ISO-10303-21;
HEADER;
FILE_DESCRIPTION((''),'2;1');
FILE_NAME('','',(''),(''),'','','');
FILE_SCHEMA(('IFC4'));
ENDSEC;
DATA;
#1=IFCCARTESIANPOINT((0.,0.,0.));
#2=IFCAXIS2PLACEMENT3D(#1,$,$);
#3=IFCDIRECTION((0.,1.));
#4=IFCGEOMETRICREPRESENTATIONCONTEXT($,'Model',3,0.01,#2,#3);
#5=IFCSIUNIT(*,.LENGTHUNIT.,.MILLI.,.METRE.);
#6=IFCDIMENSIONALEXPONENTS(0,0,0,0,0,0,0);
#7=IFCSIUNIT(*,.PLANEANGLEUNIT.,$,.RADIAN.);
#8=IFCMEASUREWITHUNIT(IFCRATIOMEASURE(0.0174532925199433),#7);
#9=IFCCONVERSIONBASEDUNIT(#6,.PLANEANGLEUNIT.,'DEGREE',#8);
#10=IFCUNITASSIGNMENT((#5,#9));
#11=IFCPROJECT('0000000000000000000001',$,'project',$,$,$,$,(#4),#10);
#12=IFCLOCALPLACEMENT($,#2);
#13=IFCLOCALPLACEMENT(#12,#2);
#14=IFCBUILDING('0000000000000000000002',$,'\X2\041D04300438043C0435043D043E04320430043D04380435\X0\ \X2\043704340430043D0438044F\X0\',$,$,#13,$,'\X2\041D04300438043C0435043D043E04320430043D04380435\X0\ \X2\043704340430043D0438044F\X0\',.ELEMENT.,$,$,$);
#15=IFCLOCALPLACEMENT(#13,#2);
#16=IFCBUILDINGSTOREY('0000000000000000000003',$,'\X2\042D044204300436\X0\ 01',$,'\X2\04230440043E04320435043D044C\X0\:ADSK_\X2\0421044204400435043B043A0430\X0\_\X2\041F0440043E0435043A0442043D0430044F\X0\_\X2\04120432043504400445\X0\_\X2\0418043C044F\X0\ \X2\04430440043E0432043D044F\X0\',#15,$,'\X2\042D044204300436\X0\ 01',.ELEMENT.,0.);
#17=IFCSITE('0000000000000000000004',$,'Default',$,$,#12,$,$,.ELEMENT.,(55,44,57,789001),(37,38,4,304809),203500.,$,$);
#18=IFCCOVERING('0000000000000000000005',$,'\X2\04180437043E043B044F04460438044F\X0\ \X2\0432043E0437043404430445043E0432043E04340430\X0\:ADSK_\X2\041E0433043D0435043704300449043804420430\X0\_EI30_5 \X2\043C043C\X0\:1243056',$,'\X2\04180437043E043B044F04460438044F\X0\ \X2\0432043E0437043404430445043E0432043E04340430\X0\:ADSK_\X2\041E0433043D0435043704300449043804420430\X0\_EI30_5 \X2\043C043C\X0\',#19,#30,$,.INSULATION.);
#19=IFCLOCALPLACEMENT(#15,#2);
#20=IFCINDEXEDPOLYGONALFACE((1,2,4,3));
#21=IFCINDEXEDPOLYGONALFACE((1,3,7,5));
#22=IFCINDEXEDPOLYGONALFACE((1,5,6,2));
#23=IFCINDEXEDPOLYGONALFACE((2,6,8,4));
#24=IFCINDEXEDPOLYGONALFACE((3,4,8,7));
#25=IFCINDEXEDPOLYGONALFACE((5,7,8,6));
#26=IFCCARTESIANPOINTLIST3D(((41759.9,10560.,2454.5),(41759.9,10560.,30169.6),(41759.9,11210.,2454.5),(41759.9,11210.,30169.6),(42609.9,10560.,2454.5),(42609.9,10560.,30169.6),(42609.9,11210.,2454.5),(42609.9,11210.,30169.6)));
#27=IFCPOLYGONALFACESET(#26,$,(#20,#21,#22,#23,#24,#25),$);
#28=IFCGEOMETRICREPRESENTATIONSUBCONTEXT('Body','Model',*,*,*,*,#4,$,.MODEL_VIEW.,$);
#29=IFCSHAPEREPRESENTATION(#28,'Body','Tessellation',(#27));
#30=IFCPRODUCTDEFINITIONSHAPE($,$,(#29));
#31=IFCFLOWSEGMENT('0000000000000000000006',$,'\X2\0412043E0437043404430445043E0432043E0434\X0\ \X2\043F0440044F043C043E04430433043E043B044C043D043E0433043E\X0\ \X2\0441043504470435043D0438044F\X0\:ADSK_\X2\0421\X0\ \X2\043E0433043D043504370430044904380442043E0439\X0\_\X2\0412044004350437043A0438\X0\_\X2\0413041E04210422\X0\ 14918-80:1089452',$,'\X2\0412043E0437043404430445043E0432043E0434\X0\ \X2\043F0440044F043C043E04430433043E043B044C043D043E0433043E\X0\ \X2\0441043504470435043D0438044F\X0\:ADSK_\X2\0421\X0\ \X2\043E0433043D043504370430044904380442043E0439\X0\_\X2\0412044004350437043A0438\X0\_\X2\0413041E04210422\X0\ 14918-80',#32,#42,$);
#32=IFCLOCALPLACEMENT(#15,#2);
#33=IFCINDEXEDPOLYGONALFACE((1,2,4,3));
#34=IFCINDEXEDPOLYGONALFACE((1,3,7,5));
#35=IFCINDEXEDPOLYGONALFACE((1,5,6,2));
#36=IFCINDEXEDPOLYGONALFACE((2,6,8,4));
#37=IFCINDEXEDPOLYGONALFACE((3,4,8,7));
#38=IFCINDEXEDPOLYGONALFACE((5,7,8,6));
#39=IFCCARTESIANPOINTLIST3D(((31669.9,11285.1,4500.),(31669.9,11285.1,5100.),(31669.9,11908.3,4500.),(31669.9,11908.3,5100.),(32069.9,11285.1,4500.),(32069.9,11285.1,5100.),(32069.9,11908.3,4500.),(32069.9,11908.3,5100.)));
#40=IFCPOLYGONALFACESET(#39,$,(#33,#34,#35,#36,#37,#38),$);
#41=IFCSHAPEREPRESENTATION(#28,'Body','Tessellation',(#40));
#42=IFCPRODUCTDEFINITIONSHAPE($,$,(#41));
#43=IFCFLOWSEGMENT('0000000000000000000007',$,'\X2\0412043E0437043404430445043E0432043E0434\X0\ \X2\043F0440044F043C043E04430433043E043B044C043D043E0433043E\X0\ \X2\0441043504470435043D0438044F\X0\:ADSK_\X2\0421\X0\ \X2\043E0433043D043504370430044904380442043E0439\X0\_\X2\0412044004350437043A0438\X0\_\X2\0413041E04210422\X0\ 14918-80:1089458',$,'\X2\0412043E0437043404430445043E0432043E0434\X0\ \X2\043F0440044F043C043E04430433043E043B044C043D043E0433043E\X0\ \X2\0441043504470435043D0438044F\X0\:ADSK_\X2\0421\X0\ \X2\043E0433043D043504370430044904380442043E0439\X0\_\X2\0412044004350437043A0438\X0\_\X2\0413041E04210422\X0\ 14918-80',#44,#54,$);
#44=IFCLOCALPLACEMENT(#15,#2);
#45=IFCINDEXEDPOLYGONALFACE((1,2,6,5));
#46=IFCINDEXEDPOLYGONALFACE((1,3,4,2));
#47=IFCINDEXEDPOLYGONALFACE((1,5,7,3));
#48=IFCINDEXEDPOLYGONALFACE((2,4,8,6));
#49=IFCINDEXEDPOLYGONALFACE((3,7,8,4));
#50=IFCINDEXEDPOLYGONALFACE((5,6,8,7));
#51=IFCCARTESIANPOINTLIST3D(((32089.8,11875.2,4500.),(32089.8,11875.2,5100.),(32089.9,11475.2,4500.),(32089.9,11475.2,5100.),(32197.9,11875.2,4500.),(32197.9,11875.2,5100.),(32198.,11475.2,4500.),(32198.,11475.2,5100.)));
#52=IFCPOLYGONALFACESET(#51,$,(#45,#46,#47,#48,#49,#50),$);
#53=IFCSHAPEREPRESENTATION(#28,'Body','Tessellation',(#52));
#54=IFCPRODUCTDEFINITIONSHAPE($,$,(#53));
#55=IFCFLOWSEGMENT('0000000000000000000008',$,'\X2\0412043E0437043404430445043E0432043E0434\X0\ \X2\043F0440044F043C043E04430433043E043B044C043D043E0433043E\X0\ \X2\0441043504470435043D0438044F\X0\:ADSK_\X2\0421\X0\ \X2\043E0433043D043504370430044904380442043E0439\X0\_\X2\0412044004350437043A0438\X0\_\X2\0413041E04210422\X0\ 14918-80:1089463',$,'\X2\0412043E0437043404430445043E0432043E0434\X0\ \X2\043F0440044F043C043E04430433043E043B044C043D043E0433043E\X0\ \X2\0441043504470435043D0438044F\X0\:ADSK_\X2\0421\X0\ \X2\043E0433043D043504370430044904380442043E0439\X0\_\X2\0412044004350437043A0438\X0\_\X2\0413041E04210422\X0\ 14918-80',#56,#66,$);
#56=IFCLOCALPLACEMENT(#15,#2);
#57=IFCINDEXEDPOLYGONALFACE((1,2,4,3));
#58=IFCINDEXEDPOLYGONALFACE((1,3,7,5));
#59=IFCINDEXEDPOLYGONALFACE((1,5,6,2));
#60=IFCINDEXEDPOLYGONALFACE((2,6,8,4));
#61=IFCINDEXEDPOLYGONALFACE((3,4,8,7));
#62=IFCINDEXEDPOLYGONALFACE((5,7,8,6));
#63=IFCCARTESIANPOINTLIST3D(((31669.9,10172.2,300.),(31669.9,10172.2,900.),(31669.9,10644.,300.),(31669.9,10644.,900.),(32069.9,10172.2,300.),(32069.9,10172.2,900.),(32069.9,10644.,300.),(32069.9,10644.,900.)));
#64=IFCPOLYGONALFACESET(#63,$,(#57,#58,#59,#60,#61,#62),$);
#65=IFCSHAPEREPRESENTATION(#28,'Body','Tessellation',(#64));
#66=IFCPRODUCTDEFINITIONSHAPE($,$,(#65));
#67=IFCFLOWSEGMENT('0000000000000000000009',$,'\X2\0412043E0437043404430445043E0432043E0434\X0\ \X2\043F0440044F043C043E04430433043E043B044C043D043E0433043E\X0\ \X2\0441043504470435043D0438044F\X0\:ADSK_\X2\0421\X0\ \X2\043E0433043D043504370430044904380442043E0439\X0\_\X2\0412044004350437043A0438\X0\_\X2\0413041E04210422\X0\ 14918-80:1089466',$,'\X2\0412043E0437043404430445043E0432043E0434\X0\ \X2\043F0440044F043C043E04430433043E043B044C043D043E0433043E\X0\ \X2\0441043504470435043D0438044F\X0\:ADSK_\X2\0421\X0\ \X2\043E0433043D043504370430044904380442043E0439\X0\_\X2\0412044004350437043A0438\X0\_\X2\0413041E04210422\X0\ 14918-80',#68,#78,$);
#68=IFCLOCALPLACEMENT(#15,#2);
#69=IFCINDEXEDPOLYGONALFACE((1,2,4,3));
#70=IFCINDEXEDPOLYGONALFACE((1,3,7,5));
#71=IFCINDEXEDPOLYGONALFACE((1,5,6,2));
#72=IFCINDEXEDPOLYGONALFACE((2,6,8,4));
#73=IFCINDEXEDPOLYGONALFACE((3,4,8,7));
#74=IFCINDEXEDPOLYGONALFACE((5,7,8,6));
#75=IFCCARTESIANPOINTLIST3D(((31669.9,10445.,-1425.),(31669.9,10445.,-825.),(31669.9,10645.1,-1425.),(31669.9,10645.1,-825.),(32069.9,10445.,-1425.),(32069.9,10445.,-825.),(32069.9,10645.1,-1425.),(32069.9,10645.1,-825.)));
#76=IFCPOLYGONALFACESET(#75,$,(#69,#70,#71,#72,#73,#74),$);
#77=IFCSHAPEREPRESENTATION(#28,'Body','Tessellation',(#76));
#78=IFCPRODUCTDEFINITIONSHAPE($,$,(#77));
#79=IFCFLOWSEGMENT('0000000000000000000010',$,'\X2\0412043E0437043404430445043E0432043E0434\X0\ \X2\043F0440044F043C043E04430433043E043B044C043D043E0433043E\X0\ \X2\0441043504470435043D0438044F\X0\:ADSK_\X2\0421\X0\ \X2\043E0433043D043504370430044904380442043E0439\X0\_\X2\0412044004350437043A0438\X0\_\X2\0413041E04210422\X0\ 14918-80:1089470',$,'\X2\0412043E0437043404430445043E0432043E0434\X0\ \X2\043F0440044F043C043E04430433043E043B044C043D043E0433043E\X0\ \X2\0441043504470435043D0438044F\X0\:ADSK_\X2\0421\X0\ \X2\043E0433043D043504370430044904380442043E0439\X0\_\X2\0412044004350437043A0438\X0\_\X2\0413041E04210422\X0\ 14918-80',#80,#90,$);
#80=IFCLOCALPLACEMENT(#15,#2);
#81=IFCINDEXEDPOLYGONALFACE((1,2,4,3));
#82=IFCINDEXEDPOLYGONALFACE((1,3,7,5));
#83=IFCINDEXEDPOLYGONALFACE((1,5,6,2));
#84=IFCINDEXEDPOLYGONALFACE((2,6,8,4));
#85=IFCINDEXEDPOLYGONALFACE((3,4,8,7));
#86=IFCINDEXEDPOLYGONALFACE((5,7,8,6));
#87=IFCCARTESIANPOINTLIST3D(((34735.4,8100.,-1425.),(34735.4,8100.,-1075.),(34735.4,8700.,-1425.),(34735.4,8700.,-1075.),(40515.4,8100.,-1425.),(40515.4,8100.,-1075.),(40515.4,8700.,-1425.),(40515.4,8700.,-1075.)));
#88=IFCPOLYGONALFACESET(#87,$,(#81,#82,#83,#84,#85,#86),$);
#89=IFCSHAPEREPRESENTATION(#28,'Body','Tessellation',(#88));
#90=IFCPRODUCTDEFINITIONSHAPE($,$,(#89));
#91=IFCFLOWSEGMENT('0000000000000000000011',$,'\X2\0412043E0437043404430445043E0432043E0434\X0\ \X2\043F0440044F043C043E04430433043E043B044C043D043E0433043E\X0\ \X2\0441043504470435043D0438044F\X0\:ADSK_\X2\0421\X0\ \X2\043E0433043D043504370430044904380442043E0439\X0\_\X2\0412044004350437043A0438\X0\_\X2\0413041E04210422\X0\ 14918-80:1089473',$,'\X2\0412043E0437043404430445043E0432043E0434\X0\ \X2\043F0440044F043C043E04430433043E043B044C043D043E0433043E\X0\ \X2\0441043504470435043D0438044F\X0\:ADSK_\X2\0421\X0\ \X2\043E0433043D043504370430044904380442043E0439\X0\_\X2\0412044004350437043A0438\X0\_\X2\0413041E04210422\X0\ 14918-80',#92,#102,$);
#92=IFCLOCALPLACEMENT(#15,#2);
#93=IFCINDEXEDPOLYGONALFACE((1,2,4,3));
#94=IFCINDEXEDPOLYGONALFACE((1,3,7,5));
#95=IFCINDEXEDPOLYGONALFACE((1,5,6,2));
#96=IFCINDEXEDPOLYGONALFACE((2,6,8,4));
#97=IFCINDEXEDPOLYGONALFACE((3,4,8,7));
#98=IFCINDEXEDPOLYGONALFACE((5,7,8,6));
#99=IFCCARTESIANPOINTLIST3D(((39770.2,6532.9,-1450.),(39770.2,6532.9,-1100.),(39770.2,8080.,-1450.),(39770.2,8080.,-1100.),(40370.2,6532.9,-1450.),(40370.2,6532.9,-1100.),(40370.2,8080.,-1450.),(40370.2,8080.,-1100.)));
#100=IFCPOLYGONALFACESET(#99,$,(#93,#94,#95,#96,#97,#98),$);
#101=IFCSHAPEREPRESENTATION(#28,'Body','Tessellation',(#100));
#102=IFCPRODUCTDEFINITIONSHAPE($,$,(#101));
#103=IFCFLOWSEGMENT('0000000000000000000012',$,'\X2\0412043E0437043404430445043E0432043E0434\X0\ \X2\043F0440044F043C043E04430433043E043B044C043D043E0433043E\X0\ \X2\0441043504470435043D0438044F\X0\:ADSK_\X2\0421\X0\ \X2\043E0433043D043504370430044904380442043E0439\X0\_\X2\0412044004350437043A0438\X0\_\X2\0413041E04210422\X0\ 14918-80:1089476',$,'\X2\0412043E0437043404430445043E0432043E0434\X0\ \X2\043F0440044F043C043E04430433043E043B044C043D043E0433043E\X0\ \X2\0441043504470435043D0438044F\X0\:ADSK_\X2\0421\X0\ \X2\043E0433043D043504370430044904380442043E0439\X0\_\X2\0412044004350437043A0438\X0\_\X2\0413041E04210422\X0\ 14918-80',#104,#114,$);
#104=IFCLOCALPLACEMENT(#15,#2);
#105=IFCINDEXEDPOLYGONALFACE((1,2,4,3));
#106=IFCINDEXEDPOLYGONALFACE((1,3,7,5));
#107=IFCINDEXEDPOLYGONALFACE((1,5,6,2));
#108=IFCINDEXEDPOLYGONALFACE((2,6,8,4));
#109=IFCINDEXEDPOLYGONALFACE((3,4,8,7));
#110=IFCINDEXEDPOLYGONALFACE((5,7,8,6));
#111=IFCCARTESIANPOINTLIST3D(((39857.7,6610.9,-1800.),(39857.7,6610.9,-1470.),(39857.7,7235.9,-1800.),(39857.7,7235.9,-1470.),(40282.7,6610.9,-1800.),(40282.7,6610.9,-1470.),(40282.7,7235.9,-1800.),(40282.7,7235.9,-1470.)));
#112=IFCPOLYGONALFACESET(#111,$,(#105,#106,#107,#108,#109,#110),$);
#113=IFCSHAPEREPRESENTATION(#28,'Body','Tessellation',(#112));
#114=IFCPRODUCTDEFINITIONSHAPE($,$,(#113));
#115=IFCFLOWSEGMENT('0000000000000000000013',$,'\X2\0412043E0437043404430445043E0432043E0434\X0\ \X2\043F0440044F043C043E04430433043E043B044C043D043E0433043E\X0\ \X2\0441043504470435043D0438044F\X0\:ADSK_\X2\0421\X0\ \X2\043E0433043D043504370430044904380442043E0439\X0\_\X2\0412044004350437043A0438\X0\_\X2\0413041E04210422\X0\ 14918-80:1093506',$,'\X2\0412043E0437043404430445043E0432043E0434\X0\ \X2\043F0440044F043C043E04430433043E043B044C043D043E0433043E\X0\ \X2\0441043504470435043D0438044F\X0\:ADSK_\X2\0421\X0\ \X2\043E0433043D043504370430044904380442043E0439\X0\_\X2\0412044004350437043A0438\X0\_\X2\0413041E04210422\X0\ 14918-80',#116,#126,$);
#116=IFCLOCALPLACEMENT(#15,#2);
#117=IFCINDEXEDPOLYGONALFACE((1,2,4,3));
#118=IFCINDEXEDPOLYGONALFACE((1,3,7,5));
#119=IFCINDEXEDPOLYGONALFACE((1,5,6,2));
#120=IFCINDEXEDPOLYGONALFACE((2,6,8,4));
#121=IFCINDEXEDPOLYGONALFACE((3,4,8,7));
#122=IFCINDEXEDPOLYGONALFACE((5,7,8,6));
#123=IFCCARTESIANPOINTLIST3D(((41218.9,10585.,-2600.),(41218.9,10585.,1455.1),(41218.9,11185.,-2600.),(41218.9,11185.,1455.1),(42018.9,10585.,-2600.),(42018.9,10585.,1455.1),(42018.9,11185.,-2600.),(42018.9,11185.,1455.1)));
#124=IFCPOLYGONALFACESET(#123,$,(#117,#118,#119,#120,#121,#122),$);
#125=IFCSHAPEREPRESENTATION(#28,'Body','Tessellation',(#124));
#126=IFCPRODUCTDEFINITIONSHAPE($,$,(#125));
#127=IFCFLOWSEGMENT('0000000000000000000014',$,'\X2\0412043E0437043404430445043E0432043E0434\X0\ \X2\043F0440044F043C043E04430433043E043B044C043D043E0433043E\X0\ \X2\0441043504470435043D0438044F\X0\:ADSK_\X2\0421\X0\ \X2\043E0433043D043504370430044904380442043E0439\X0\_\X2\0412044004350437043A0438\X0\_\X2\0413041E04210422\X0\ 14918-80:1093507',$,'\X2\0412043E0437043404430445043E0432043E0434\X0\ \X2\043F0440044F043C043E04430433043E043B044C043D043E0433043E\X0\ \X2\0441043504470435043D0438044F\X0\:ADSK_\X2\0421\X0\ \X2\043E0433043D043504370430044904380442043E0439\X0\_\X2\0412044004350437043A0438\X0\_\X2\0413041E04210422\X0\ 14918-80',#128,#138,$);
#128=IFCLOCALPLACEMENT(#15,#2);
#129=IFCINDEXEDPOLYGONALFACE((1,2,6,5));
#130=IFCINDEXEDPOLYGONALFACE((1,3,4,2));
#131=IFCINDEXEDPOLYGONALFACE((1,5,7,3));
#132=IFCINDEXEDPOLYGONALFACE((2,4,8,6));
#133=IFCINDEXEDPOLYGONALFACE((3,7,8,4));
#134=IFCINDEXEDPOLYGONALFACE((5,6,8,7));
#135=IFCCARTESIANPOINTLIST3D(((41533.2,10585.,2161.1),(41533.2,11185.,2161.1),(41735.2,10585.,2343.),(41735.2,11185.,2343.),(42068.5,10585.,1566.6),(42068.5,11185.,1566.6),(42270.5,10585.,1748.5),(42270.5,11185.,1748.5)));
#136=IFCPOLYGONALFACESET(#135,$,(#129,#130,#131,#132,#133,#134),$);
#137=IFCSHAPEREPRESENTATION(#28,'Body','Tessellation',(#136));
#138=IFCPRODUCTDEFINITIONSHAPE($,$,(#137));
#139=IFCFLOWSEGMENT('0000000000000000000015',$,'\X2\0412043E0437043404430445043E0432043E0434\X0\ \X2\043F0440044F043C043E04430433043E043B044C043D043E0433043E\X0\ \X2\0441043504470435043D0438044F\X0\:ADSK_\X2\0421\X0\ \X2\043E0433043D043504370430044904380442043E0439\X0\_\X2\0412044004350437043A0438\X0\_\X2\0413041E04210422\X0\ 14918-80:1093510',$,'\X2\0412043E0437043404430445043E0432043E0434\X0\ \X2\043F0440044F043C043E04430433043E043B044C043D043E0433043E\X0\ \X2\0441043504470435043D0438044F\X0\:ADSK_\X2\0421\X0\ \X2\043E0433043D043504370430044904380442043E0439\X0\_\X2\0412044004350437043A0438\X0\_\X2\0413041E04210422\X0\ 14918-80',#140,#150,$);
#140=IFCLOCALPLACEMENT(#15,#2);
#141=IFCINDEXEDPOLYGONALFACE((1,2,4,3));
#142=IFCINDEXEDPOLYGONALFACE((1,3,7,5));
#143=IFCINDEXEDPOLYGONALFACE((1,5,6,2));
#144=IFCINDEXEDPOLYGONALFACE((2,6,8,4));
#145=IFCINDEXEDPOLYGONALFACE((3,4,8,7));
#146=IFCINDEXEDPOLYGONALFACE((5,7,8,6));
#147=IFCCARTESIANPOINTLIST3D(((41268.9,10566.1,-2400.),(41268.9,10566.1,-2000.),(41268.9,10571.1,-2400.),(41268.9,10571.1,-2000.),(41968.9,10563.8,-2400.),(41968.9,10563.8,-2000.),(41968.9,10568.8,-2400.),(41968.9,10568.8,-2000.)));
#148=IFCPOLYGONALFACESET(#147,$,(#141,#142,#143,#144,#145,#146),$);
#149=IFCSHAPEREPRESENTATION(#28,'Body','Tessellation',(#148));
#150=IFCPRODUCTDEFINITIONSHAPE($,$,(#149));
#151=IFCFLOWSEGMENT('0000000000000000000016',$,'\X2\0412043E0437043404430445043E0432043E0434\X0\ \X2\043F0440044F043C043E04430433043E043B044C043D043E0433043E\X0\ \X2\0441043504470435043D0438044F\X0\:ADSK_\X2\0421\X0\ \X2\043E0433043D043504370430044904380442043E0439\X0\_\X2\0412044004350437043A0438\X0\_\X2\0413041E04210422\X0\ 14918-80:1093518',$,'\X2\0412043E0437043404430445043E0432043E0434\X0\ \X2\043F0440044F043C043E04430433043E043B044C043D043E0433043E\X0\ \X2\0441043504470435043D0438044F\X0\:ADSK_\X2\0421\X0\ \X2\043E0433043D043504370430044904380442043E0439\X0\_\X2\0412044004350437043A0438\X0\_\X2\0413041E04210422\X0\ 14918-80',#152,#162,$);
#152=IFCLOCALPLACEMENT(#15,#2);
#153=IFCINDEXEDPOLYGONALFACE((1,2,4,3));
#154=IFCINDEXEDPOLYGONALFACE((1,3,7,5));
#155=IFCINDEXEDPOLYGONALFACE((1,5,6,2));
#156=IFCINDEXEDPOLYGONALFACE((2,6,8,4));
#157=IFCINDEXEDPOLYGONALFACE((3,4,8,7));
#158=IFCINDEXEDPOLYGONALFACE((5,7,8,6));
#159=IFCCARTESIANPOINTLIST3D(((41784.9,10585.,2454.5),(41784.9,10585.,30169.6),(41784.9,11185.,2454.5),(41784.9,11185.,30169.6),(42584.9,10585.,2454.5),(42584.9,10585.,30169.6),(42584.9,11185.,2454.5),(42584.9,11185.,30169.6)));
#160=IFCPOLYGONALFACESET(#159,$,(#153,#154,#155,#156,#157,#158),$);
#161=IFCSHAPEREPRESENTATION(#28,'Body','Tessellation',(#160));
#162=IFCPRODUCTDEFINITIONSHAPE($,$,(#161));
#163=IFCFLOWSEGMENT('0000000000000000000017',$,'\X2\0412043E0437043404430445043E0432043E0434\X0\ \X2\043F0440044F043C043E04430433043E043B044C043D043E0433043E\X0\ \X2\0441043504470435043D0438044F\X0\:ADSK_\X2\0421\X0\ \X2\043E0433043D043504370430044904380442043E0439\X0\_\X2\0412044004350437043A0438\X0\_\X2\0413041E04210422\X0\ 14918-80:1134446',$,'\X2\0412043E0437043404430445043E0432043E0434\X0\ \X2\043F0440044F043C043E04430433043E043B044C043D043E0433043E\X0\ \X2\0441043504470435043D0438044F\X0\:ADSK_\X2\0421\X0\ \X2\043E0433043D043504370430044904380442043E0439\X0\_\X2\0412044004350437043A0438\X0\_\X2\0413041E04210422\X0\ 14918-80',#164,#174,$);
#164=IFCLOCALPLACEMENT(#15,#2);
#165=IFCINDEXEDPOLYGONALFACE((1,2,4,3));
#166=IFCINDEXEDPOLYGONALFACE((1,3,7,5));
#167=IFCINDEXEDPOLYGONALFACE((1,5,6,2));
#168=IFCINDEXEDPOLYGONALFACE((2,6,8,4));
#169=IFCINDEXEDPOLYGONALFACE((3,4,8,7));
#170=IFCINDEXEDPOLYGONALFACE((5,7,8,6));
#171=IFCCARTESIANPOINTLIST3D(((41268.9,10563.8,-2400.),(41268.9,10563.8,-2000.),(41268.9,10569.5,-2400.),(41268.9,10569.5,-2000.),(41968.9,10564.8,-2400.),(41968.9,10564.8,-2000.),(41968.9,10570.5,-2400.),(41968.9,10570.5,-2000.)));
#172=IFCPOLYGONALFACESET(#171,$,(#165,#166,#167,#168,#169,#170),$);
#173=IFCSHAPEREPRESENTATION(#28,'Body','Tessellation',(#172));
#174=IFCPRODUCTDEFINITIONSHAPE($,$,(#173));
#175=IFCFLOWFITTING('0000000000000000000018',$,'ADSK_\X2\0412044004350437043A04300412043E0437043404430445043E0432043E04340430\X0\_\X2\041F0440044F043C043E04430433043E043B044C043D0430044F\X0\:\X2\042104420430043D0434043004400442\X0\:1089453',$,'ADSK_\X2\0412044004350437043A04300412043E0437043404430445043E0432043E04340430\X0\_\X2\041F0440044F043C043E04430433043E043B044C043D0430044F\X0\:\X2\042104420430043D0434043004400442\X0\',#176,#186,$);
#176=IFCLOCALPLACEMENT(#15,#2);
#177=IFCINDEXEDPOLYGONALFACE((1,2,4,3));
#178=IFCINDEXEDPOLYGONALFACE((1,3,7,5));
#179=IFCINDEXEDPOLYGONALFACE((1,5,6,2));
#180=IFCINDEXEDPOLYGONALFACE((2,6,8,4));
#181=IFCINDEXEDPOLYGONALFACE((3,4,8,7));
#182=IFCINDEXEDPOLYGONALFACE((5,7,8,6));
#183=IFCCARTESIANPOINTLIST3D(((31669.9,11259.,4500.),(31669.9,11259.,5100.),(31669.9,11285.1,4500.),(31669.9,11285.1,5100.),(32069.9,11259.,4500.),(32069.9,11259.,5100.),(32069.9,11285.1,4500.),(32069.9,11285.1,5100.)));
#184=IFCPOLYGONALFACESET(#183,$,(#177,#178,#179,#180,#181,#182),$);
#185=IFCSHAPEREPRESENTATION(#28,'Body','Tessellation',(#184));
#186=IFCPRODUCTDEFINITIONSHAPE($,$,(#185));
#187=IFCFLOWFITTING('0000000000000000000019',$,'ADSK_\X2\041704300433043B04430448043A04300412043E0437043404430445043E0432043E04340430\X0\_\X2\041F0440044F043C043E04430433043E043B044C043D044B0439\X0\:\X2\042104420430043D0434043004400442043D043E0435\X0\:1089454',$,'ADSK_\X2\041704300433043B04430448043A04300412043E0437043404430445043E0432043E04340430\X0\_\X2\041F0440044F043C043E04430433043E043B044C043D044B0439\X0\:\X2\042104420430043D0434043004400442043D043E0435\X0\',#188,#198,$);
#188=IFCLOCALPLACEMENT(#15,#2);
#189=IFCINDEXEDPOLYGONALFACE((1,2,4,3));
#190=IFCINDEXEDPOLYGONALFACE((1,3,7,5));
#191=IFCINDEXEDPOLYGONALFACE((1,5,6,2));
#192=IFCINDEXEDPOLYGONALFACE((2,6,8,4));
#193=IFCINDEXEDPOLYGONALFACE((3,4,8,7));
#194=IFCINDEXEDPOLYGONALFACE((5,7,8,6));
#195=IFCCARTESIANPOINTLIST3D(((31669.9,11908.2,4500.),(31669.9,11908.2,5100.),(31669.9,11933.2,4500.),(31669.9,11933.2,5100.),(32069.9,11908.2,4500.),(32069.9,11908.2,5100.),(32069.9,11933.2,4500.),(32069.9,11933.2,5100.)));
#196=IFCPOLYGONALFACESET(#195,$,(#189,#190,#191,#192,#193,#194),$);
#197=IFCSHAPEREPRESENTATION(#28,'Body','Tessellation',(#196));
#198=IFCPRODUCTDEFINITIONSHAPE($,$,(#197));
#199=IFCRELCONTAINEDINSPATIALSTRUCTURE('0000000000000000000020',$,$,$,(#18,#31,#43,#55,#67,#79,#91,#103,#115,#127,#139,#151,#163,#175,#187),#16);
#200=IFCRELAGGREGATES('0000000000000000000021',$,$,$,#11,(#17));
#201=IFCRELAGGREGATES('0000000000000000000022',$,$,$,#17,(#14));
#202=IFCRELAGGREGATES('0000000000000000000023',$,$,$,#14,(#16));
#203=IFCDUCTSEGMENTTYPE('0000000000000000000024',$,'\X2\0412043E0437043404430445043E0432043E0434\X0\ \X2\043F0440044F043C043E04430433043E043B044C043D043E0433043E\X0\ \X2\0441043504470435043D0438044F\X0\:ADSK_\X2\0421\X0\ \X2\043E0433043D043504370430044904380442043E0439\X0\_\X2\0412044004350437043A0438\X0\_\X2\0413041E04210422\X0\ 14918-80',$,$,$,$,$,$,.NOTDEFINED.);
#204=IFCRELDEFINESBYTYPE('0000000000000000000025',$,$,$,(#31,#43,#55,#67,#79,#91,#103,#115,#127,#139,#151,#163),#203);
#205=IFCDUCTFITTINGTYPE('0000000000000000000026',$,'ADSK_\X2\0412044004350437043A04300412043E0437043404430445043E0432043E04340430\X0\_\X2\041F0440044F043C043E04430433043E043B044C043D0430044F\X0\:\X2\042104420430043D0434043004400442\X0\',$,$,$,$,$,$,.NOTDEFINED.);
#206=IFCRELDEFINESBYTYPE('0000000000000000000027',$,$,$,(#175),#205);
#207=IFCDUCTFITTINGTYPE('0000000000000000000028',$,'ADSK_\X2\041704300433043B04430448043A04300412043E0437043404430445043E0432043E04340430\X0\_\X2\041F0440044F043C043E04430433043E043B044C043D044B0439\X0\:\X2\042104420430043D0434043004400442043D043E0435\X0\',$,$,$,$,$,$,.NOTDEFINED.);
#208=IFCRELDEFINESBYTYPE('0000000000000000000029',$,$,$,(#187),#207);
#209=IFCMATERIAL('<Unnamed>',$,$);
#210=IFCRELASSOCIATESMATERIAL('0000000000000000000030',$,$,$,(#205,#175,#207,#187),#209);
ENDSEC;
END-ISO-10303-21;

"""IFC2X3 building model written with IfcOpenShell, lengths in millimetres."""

from ifc_helpers import new_model, entity, si_unit, converted_unit, direction, frame, origin, origin_2d_with_axis, place, context, subcontext, project, spatial, rectangle, extrude, source, transform, mapped, material, type_object, type_shapes, element, save


model = new_model("IFC2X3")

# Units and contexts
model_context = context("Model", 3, precision=0.01, world=origin(), true_north=direction((0.0, 1.0)))
body_context = subcontext(model_context, "Body", "Model", "MODEL_VIEW")
ifc_project = project(units=[si_unit("LENGTHUNIT", "METRE", prefix="MILLI"), converted_unit("PLANEANGLEUNIT", "DEGREE", entity("IfcRatioMeasure", 0.0174532925199433), si_unit("PLANEANGLEUNIT", "RADIAN"), dimensions=[0, 0, 0, 0, 0, 0, 0])], contexts=[model_context])

# Site, building, storey
site_placement = place(None, origin())
site = spatial("IfcSite", under=ifc_project, at=site_placement, Name="Default", CompositionType="ELEMENT", RefLatitude=(55, 44, 57, 789001), RefLongitude=(37, 38, 4, 304809), RefElevation=203500.0)
building_placement = place(site_placement, origin())
building = spatial("IfcBuilding", under=site, at=building_placement, Name="Наименование здания", LongName="Наименование здания", CompositionType="ELEMENT")
storey_placement = place(building_placement, origin())
storey = spatial("IfcBuildingStorey", under=building, at=storey_placement, Name="Этаж 01", ObjectType="Уровень:ADSK_Стрелка_Проектная_Вверх_Имя уровня", LongName="Этаж 01", CompositionType="ELEMENT", Elevation=0.0)

# Covering
covering_placement = place(storey_placement, frame((41759.9, 10560.0, 2454.5)))
element("IfcCovering", 1, at=covering_placement, inside=storey, Name="Изоляция воздуховода:ADSK_Огнезащита_EI30_5 мм:1243056", ObjectType="Изоляция воздуховода:ADSK_Огнезащита_EI30_5 мм", PredefinedType="INSULATION", context=body_context, shape_type="SweptSolid", body=[
    extrude(rectangle(XDim=850.0, YDim=650.0, at=origin_2d_with_axis()), frame((425.0, 325.0, 0.0), z_axis=(0.0, 0.0, 1.0), x_axis=(-1.0, 0.0, 0.0)), (0.0, 0.0, 1.0), 27715.1),
])

# Flow segments
duct_segment_type = type_object("IfcDuctSegmentType", Name="Воздуховод прямоугольного сечения:ADSK_С огнезащитой_Врезки_ГОСТ 14918-80", PredefinedType="NOTDEFINED")
flow_segment_1_placement = place(storey_placement, frame((31669.9, 11285.1, 4500.0)))
element("IfcFlowSegment", 2, at=flow_segment_1_placement, inside=storey, type_object=duct_segment_type, Name="Воздуховод прямоугольного сечения:ADSK_С огнезащитой_Врезки_ГОСТ 14918-80:1089452", ObjectType="Воздуховод прямоугольного сечения:ADSK_С огнезащитой_Врезки_ГОСТ 14918-80", context=body_context, shape_type="SweptSolid", body=[
    extrude(rectangle(XDim=623.2, YDim=400.0, at=origin_2d_with_axis()), frame((200.0, 311.6, 0.0), z_axis=(0.0, 0.0, 1.0), x_axis=(0.0, 1.0, 0.0)), (0.0, 0.0, 1.0), 600.0),
])
flow_segment_2_placement = place(storey_placement, frame((32089.8, 11475.2, 4500.0)))
element("IfcFlowSegment", 3, at=flow_segment_2_placement, inside=storey, type_object=duct_segment_type, Name="Воздуховод прямоугольного сечения:ADSK_С огнезащитой_Врезки_ГОСТ 14918-80:1089458", ObjectType="Воздуховод прямоугольного сечения:ADSK_С огнезащитой_Врезки_ГОСТ 14918-80", context=body_context, shape_type="SweptSolid", body=[
    extrude(rectangle(XDim=108.1, YDim=400.0, at=origin_2d_with_axis()), frame((54.1, 200.0, 0.0), z_axis=(0.0, 0.0, 1.0), x_axis=(1.0, 0.000152, 0.0)), (0.0, 0.0, 1.0), 600.0),
])
flow_segment_3_placement = place(storey_placement, frame((31669.9, 10172.2, 300.0)))
element("IfcFlowSegment", 4, at=flow_segment_3_placement, inside=storey, type_object=duct_segment_type, Name="Воздуховод прямоугольного сечения:ADSK_С огнезащитой_Врезки_ГОСТ 14918-80:1089463", ObjectType="Воздуховод прямоугольного сечения:ADSK_С огнезащитой_Врезки_ГОСТ 14918-80", context=body_context, shape_type="SweptSolid", body=[
    extrude(rectangle(XDim=471.8, YDim=400.0, at=origin_2d_with_axis()), frame((200.0, 235.9, 0.0), z_axis=(0.0, 0.0, 1.0), x_axis=(0.000035, -1.0, 0.0)), (0.0, 0.0, 1.0), 600.0),
])
flow_segment_4_placement = place(storey_placement, frame((31669.9, 10445.0, -1425.0)))
element("IfcFlowSegment", 5, at=flow_segment_4_placement, inside=storey, type_object=duct_segment_type, Name="Воздуховод прямоугольного сечения:ADSK_С огнезащитой_Врезки_ГОСТ 14918-80:1089466", ObjectType="Воздуховод прямоугольного сечения:ADSK_С огнезащитой_Врезки_ГОСТ 14918-80", context=body_context, shape_type="SweptSolid", body=[
    extrude(rectangle(XDim=200.1, YDim=400.0, at=origin_2d_with_axis()), frame((200.0, 100.0, 0.0), z_axis=(0.0, 0.0, 1.0), x_axis=(0.0, 1.0, 0.0)), (0.0, 0.0, 1.0), 600.0),
])
flow_segment_5_placement = place(storey_placement, frame((34735.4, 8100.0, -1425.0)))
element("IfcFlowSegment", 6, at=flow_segment_5_placement, inside=storey, type_object=duct_segment_type, Name="Воздуховод прямоугольного сечения:ADSK_С огнезащитой_Врезки_ГОСТ 14918-80:1089470", ObjectType="Воздуховод прямоугольного сечения:ADSK_С огнезащитой_Врезки_ГОСТ 14918-80", context=body_context, shape_type="SweptSolid", body=[
    extrude(rectangle(XDim=5780.0, YDim=600.0, at=origin_2d_with_axis()), frame((2890.0, 300.0, 0.0), z_axis=(0.0, 0.0, 1.0), x_axis=(-1.0, 0.0, 0.0)), (0.0, 0.0, 1.0), 350.0),
])
flow_segment_6_placement = place(storey_placement, frame((39770.2, 6532.9, -1450.0)))
element("IfcFlowSegment", 7, at=flow_segment_6_placement, inside=storey, type_object=duct_segment_type, Name="Воздуховод прямоугольного сечения:ADSK_С огнезащитой_Врезки_ГОСТ 14918-80:1089473", ObjectType="Воздуховод прямоугольного сечения:ADSK_С огнезащитой_Врезки_ГОСТ 14918-80", context=body_context, shape_type="SweptSolid", body=[
    extrude(rectangle(XDim=1547.1, YDim=600.0, at=origin_2d_with_axis()), frame((300.0, 773.6, 0.0), z_axis=(0.0, 0.0, 1.0), x_axis=(0.0, 1.0, 0.0)), (0.0, 0.0, 1.0), 350.0),
])
flow_segment_7_placement = place(storey_placement, frame((39857.7, 6610.9, -1800.0)))
element("IfcFlowSegment", 8, at=flow_segment_7_placement, inside=storey, type_object=duct_segment_type, Name="Воздуховод прямоугольного сечения:ADSK_С огнезащитой_Врезки_ГОСТ 14918-80:1089476", ObjectType="Воздуховод прямоугольного сечения:ADSK_С огнезащитой_Врезки_ГОСТ 14918-80", context=body_context, shape_type="SweptSolid", body=[
    extrude(rectangle(XDim=625.0, YDim=425.0, at=origin_2d_with_axis()), frame((212.5, 312.5, 0.0), z_axis=(0.0, 0.0, 1.0), x_axis=(0.0, -1.0, 0.0)), (0.0, 0.0, 1.0), 330.0),
])
flow_segment_8_placement = place(storey_placement, frame((41218.9, 10585.0, -2600.0)))
element("IfcFlowSegment", 9, at=flow_segment_8_placement, inside=storey, type_object=duct_segment_type, Name="Воздуховод прямоугольного сечения:ADSK_С огнезащитой_Врезки_ГОСТ 14918-80:1093506", ObjectType="Воздуховод прямоугольного сечения:ADSK_С огнезащитой_Врезки_ГОСТ 14918-80", context=body_context, shape_type="SweptSolid", body=[
    extrude(rectangle(XDim=600.0, YDim=800.0, at=origin_2d_with_axis()), frame((400.0, 300.0, 0.0), z_axis=(0.0, 0.0, 1.0), x_axis=(0.0, -1.0, 0.0)), (0.0, 0.0, 1.0), 4055.1),
])
flow_segment_9_placement = place(storey_placement, frame((41533.2, 10585.0, 1566.6)))
element("IfcFlowSegment", 10, at=flow_segment_9_placement, inside=storey, type_object=duct_segment_type, Name="Воздуховод прямоугольного сечения:ADSK_С огнезащитой_Врезки_ГОСТ 14918-80:1093507", ObjectType="Воздуховод прямоугольного сечения:ADSK_С огнезащитой_Врезки_ГОСТ 14918-80", context=body_context, shape_type="SweptSolid", body=[
    extrude(rectangle(XDim=271.9, YDim=600.0, at=origin_2d_with_axis()), frame((636.3, 300.0, 91.0), z_axis=(-0.669131, 0.0, 0.743145), x_axis=(-0.743145, 0.0, -0.669131)), (0.0, 0.0, 1.0), 800.0),
])
flow_segment_10_placement = place(storey_placement, frame((41268.9, 10563.8, -2400.0)))
element("IfcFlowSegment", 11, at=flow_segment_10_placement, inside=storey, type_object=duct_segment_type, Name="Воздуховод прямоугольного сечения:ADSK_С огнезащитой_Врезки_ГОСТ 14918-80:1093510", ObjectType="Воздуховод прямоугольного сечения:ADSK_С огнезащитой_Врезки_ГОСТ 14918-80", context=body_context, shape_type="SweptSolid", body=[
    extrude(rectangle(XDim=5.0, YDim=700.0, at=origin_2d_with_axis()), frame((350.0, 3.6, 0.0), z_axis=(0.0, 0.0, 1.0), x_axis=(0.003286, 0.999995, 0.0)), (0.0, 0.0, 1.0), 400.0),
])
flow_segment_11_placement = place(storey_placement, frame((41784.9, 10585.0, 2454.5)))
element("IfcFlowSegment", 12, at=flow_segment_11_placement, inside=storey, type_object=duct_segment_type, Name="Воздуховод прямоугольного сечения:ADSK_С огнезащитой_Врезки_ГОСТ 14918-80:1093518", ObjectType="Воздуховод прямоугольного сечения:ADSK_С огнезащитой_Врезки_ГОСТ 14918-80", context=body_context, shape_type="SweptSolid", body=[
    extrude(rectangle(XDim=800.0, YDim=600.0, at=origin_2d_with_axis()), frame((400.0, 300.0, 0.0)), (0.0, 0.0, 1.0), 27715.1),
])
flow_segment_12_placement = place(storey_placement, frame((41268.9, 10563.8, -2400.0)))
element("IfcFlowSegment", 13, at=flow_segment_12_placement, inside=storey, type_object=duct_segment_type, Name="Воздуховод прямоугольного сечения:ADSK_С огнезащитой_Врезки_ГОСТ 14918-80:1134446", ObjectType="Воздуховод прямоугольного сечения:ADSK_С огнезащитой_Врезки_ГОСТ 14918-80", context=body_context, shape_type="SweptSolid", body=[
    extrude(rectangle(XDim=5.7, YDim=700.0, at=origin_2d_with_axis()), frame((350.0, 3.4, 0.0), z_axis=(0.0, 0.0, 1.0), x_axis=(-0.001494, 0.999999, 0.0)), (0.0, 0.0, 1.0), 400.0),
])

# Flow fittings
ifc_material_1 = material(Name="<Unnamed>")
duct_fitting_type_1 = type_object("IfcDuctFittingType", Name="ADSK_ВрезкаВоздуховода_Прямоугольная:Стандарт", PredefinedType="NOTDEFINED", material=ifc_material_1)
shared_shape_1 = source(origin(), body_context, "Body", "SweptSolid", [
    extrude(rectangle(XDim=26.1, YDim=600.0, at=origin_2d_with_axis()), frame((7.0, 0.0, -200.0)), (0.0, 0.0, 1.0), 400.0),
])
type_shapes(duct_fitting_type_1, [shared_shape_1])
flow_fitting_1_placement = place(storey_placement, frame((31869.9, 11265.1, 4800.0), z_axis=(1.0, 0.0, 0.0), x_axis=(0.0, 1.0, 0.0)))
element("IfcFlowFitting", 14, at=flow_fitting_1_placement, inside=storey, type_object=duct_fitting_type_1, material=ifc_material_1, Name="ADSK_ВрезкаВоздуховода_Прямоугольная:Стандарт:1089453", ObjectType="ADSK_ВрезкаВоздуховода_Прямоугольная:Стандарт", context=body_context, shape_type="MappedRepresentation", body=[
    mapped(shared_shape_1, transform((0.0, 0.0, 0.0), scale=1.0)),
])
duct_fitting_type_2 = type_object("IfcDuctFittingType", Name="ADSK_ЗаглушкаВоздуховода_Прямоугольный:Стандартное", PredefinedType="NOTDEFINED", material=ifc_material_1)
shared_shape_2 = source(origin(), body_context, "Body", "SweptSolid", [
    extrude(rectangle(XDim=25.0, YDim=400.0, at=origin_2d_with_axis()), frame((12.5, 0.0, -300.0)), (0.0, 0.0, 1.0), 600.0),
])
type_shapes(duct_fitting_type_2, [shared_shape_2])
for number, where, z_axis, x_axis, name in (
    (15, (31869.9, 11908.2, 4800.0), (0.0, 0.0, 1.0), (0.0, 1.0, 0.0), "ADSK_ЗаглушкаВоздуховода_Прямоугольный:Стандартное:1089454"),
):
    element("IfcFlowFitting", number, at=place(storey_placement, frame(where, z_axis=z_axis, x_axis=x_axis)), inside=storey, type_object=duct_fitting_type_2, material=ifc_material_1, Name=name, ObjectType="ADSK_ЗаглушкаВоздуховода_Прямоугольный:Стандартное", context=body_context, shape_type="MappedRepresentation", body=[
        mapped(shared_shape_2, transform((0.0, 0.0, 0.0), scale=1.0)),
    ])

save(model, "model.ifc")
